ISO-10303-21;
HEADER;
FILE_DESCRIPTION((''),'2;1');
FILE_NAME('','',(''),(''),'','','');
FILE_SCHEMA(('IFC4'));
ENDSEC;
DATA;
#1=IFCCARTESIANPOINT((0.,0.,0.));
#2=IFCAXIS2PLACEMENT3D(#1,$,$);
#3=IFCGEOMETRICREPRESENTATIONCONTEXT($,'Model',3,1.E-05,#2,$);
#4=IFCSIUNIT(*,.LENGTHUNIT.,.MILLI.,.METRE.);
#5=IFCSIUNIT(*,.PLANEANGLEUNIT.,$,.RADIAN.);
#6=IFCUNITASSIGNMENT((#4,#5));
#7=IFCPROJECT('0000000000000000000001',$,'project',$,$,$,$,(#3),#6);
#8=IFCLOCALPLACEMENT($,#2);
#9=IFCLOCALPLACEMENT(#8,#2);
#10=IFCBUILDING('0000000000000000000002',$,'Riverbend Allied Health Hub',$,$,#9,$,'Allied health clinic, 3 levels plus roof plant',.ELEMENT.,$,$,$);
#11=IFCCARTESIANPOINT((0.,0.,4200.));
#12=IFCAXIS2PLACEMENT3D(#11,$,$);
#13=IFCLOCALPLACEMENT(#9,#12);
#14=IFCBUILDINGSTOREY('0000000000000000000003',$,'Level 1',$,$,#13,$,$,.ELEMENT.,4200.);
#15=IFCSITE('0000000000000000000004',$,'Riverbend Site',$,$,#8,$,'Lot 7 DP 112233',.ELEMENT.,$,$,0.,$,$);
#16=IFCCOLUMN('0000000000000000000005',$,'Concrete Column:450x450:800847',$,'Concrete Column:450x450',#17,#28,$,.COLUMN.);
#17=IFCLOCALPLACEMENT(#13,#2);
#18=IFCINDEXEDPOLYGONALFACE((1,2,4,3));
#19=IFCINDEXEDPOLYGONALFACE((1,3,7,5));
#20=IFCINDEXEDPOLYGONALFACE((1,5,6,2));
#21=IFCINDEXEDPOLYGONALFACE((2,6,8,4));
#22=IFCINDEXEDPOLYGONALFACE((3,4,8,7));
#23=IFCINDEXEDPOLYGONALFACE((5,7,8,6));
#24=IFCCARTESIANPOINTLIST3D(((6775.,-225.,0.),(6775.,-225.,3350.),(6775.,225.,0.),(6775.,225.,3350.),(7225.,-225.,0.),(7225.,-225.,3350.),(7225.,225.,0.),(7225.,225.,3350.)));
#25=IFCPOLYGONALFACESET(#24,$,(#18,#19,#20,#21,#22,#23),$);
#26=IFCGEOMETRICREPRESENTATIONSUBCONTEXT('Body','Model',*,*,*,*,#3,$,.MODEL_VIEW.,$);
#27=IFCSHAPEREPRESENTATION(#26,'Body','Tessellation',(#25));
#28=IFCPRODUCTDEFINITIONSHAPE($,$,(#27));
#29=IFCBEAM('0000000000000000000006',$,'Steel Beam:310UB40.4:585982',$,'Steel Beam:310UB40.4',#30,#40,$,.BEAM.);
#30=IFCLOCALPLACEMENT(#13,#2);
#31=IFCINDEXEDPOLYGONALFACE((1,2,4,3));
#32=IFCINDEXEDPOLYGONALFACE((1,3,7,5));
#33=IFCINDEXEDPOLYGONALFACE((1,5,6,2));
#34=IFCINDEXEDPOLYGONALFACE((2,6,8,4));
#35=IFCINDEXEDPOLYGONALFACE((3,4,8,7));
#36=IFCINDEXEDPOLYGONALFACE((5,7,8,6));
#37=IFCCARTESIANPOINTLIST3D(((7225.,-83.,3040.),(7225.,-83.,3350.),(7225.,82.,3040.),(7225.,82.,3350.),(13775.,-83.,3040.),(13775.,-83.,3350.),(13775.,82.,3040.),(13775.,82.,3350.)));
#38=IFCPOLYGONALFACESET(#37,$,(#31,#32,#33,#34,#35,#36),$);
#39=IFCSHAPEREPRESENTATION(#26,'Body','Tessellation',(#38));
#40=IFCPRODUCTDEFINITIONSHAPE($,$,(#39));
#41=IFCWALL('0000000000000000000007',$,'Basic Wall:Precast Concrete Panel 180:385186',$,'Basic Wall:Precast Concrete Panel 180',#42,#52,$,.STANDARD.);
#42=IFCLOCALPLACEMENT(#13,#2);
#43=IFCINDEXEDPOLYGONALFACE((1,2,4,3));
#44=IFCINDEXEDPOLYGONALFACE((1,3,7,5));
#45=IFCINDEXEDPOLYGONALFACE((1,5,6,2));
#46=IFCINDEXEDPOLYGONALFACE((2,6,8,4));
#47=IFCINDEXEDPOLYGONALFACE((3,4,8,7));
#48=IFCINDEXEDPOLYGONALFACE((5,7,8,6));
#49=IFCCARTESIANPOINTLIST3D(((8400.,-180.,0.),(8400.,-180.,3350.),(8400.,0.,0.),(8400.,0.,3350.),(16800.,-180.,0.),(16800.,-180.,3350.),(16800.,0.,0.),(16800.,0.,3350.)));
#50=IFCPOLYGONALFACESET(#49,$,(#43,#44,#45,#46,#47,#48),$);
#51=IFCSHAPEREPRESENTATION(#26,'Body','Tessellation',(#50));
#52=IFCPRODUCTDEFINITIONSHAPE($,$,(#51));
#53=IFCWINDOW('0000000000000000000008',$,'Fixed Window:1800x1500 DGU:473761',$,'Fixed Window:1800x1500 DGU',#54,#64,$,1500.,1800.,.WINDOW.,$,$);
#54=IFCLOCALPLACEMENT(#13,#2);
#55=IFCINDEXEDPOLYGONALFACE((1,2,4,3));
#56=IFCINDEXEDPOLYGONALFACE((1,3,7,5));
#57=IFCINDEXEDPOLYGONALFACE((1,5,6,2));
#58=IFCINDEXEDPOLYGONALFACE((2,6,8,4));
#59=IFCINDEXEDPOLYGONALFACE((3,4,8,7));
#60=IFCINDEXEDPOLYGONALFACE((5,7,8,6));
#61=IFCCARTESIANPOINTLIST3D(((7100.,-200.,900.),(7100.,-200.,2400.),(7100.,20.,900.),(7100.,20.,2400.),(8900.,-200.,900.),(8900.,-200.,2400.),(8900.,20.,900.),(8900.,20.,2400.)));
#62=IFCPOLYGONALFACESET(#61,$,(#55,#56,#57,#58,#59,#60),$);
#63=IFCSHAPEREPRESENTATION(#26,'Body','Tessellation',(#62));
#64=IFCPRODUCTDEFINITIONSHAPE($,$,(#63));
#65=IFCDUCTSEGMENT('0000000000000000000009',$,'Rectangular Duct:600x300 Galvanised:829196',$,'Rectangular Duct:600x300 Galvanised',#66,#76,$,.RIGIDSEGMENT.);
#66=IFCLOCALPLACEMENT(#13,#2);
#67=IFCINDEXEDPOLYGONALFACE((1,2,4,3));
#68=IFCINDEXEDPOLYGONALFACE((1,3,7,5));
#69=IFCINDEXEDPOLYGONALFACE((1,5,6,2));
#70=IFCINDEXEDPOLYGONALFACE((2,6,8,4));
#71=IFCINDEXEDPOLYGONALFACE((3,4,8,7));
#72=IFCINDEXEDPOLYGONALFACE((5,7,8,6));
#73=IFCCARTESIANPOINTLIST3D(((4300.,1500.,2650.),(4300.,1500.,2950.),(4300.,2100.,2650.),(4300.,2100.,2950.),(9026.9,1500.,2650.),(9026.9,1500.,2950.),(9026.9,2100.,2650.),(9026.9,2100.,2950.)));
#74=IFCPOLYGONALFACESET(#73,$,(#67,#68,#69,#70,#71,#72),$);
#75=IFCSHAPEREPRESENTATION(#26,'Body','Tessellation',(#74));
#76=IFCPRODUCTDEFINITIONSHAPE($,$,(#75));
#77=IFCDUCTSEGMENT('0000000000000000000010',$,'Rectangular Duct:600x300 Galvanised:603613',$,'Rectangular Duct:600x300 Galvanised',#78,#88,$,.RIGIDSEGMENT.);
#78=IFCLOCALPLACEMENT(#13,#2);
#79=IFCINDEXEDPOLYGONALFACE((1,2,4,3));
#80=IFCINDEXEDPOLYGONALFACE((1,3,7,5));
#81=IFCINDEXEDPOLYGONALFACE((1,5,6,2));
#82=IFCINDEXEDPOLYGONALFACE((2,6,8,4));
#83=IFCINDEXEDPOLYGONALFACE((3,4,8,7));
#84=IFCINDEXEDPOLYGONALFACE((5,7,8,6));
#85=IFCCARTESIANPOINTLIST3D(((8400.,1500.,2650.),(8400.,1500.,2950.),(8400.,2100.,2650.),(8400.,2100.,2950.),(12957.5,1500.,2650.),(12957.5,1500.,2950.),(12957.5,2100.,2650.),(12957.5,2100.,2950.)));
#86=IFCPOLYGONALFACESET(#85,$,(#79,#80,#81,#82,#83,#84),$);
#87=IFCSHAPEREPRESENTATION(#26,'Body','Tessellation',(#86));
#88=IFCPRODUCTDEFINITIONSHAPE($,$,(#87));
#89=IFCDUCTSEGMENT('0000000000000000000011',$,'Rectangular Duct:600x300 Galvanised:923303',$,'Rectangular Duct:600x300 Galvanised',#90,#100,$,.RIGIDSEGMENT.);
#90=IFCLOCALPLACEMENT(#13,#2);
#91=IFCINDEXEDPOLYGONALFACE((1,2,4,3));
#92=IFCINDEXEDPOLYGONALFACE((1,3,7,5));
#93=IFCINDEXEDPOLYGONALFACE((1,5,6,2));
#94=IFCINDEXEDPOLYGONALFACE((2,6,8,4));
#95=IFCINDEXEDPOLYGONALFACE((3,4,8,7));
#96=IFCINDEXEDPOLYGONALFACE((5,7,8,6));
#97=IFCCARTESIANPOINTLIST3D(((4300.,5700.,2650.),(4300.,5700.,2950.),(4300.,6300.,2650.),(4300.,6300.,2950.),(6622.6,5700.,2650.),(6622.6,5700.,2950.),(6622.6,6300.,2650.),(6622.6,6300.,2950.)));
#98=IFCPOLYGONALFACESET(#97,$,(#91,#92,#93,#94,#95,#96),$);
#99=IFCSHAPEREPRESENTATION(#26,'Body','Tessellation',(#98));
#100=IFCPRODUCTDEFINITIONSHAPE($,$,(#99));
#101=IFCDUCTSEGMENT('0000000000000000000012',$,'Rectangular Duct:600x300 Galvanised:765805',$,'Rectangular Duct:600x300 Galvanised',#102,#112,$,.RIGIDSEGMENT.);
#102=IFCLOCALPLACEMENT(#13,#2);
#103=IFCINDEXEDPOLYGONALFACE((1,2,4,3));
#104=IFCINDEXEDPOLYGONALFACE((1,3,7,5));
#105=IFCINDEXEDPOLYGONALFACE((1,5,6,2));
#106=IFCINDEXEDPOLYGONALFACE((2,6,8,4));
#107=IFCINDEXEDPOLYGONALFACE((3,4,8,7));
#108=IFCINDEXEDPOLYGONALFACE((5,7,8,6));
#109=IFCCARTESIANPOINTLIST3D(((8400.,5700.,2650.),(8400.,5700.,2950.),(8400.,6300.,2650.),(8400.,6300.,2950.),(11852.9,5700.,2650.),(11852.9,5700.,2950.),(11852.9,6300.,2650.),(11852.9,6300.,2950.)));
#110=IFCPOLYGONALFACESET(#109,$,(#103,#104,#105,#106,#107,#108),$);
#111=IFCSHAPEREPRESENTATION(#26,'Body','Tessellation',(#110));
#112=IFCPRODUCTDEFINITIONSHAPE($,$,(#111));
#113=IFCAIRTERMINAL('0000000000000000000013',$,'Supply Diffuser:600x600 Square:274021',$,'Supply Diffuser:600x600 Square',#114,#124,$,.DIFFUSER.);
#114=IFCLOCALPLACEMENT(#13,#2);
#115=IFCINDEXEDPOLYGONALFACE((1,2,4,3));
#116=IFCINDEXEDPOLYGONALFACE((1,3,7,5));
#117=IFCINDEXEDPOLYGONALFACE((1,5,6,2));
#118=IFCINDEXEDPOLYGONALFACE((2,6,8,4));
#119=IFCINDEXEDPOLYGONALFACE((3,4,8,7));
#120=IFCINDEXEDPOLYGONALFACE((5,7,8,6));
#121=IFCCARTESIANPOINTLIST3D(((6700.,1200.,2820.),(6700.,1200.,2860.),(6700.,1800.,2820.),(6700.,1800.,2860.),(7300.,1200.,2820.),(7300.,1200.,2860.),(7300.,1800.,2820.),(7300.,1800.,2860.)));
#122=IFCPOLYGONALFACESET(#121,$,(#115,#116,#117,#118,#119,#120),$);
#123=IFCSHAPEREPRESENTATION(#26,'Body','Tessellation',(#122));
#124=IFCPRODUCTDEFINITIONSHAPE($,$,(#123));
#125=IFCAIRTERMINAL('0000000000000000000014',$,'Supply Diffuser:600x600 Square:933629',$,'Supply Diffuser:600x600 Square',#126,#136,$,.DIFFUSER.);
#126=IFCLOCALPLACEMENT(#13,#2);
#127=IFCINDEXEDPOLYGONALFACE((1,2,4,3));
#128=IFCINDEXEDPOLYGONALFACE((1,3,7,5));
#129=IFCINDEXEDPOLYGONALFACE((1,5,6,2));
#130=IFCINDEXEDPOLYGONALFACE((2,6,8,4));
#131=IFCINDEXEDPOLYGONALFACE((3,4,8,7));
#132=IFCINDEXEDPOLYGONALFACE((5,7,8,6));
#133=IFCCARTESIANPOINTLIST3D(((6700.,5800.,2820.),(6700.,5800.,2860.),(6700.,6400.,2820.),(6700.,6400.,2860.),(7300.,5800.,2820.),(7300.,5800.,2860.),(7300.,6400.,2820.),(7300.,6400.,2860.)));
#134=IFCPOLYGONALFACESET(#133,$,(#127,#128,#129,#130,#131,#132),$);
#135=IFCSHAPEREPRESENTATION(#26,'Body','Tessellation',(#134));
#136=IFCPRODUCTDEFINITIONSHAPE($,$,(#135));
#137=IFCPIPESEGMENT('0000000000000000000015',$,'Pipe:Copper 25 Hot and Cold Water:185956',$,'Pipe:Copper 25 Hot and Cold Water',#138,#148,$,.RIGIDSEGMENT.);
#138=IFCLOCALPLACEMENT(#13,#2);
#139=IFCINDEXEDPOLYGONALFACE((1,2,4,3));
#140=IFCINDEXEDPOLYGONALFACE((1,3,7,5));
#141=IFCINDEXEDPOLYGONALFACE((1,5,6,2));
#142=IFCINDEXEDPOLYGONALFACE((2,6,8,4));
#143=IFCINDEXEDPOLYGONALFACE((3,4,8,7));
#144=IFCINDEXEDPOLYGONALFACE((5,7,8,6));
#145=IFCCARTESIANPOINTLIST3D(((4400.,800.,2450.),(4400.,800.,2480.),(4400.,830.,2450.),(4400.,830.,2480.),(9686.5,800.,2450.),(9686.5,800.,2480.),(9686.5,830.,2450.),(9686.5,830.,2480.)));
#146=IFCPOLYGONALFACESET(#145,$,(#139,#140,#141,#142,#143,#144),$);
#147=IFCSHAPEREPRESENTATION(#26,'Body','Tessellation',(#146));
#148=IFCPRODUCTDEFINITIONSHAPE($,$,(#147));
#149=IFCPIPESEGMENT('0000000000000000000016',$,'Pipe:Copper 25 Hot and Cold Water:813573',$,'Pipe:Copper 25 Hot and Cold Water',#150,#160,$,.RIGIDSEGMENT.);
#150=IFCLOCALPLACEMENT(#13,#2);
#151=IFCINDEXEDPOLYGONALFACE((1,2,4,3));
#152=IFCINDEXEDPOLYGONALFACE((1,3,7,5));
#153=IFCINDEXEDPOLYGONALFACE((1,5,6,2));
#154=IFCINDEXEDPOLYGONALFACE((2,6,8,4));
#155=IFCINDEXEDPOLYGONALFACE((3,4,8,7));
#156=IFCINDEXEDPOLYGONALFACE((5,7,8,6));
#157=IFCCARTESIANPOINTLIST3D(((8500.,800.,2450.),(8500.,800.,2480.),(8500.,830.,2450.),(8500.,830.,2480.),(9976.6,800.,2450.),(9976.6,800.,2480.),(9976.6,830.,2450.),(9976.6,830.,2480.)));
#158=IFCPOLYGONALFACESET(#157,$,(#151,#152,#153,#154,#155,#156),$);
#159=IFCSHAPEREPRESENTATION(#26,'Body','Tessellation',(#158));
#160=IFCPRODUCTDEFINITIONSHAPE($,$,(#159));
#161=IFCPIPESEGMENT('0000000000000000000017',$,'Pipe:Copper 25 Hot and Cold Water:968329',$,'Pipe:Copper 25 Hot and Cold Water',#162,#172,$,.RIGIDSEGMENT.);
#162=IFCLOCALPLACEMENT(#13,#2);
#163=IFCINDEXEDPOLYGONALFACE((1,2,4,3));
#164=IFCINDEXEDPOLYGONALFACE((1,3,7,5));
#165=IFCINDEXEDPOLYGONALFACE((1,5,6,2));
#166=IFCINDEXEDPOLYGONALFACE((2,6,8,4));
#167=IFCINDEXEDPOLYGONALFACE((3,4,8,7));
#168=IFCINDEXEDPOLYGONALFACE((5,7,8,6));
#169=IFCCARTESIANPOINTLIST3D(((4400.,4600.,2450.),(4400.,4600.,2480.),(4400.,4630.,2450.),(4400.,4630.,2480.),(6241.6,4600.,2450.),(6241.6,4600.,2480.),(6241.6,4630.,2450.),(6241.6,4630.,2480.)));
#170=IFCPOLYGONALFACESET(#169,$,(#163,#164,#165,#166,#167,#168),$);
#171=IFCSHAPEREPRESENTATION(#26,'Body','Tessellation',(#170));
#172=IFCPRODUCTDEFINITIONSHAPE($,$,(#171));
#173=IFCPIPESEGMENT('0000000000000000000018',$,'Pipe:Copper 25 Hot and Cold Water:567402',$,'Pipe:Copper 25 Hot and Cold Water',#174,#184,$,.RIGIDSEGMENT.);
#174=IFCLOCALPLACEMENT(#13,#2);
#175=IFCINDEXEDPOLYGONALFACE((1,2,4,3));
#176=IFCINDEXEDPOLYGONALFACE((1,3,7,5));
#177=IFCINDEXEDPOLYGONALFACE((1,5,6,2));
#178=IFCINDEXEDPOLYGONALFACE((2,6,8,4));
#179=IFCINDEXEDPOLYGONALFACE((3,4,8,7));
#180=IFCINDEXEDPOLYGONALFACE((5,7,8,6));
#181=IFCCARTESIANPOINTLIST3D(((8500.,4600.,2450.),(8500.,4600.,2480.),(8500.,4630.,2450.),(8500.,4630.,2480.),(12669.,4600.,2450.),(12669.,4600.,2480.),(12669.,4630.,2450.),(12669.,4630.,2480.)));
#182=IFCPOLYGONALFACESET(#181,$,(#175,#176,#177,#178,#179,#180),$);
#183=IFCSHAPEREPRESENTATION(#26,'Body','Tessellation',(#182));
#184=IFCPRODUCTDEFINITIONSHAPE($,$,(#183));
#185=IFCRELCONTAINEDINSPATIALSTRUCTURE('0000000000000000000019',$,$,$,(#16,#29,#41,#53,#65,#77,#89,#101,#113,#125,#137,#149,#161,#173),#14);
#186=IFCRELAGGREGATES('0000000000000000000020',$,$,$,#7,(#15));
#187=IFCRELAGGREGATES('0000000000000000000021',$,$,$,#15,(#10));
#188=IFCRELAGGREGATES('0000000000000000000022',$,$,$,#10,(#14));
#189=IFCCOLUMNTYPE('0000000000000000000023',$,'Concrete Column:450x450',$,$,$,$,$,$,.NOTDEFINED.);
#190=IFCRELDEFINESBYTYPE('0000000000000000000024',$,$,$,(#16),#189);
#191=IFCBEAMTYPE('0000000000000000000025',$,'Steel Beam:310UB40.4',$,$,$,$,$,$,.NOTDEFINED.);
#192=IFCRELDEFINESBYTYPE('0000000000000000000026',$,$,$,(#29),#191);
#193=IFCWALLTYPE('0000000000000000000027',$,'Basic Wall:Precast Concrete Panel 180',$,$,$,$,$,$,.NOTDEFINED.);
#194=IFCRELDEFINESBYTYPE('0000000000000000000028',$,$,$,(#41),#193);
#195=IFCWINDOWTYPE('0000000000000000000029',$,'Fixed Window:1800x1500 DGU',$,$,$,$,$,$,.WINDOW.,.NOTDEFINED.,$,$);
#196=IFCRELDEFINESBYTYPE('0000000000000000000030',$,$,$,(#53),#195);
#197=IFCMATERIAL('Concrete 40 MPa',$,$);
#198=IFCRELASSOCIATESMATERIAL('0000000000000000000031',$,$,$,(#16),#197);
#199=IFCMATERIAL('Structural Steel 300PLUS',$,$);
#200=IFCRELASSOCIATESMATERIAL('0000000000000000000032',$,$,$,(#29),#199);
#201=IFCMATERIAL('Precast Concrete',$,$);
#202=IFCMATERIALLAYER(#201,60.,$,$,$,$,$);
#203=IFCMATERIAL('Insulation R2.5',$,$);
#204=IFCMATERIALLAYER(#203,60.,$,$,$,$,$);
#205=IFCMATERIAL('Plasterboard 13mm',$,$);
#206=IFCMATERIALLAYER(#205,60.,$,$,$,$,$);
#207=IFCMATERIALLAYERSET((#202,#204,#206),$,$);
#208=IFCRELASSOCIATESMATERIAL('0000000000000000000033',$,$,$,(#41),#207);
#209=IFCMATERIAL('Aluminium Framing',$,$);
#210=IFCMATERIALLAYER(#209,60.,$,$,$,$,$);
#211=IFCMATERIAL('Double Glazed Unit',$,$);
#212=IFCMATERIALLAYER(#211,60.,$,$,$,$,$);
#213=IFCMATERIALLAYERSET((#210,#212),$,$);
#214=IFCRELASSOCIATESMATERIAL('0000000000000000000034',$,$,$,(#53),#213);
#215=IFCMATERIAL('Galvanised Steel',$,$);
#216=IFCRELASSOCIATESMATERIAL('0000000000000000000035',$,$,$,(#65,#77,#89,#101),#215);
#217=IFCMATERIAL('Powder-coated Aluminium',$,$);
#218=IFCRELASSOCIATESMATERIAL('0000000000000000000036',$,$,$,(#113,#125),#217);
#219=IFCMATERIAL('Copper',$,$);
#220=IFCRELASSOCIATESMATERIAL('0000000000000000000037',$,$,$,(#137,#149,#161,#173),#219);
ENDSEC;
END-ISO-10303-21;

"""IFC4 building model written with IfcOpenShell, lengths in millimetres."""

from ifc_helpers import new_model, si_unit, frame, frame_2d, origin, place, context, subcontext, project, spatial, rectangle, extrude, material, layer, layer_set, layer_usage, type_object, element, save


model = new_model("IFC4")

# Units and contexts
model_context = context("Model", 3, precision=1e-05, world=origin())
body_context = subcontext(model_context, "Body", "Model", "MODEL_VIEW")
ifc_project = project(units=[si_unit("LENGTHUNIT", "METRE", prefix="MILLI"), si_unit("PLANEANGLEUNIT", "RADIAN")], contexts=[model_context])

# Site, building, storey
site_placement = place(None, origin())
site = spatial("IfcSite", under=ifc_project, at=site_placement, Name="Riverbend Site", LongName="Lot 7 DP 112233", CompositionType="ELEMENT", RefElevation=0.0)
building_placement = place(site_placement, origin())
building = spatial("IfcBuilding", under=site, at=building_placement, Name="Riverbend Allied Health Hub", LongName="Allied health clinic, 3 levels plus roof plant", CompositionType="ELEMENT")
storey_placement = place(building_placement, frame((0.0, 0.0, 4200.0)))
storey = spatial("IfcBuildingStorey", under=building, at=storey_placement, Name="Level 1", CompositionType="ELEMENT", Elevation=4200.0)

# Column
ifc_material_1 = material(Name="Concrete 40 MPa")
column_type = type_object("IfcColumnType", Name="Concrete Column:450x450", PredefinedType="NOTDEFINED")
column_placement = place(storey_placement, frame((6775.0, -225.0, 0.0)))
element("IfcColumn", 1, at=column_placement, inside=storey, type_object=column_type, material=ifc_material_1, Name="Concrete Column:450x450:800847", ObjectType="Concrete Column:450x450", PredefinedType="COLUMN", context=body_context, shape_type="SweptSolid", body=[
    extrude(rectangle(XDim=450.0, YDim=450.0, at=frame_2d((225.0, 225.0))), origin(), (0.0, 0.0, 1.0), 3350.0),
])

# Beam
ifc_material_2 = material(Name="Structural Steel 300PLUS")
beam_type = type_object("IfcBeamType", Name="Steel Beam:310UB40.4", PredefinedType="NOTDEFINED")
beam_placement = place(storey_placement, frame((7225.0, -83.0, 3040.0)))
element("IfcBeam", 2, at=beam_placement, inside=storey, type_object=beam_type, material=ifc_material_2, Name="Steel Beam:310UB40.4:585982", ObjectType="Steel Beam:310UB40.4", PredefinedType="BEAM", context=body_context, shape_type="SweptSolid", body=[
    extrude(rectangle(XDim=6550.0, YDim=165.0, at=frame_2d((3275.0, 82.5))), origin(), (0.0, 0.0, 1.0), 310.0),
])

# Wall
ifc_material_3 = material(Name="Precast Concrete")
ifc_layer_1 = layer(ifc_material_3, 60.0)
ifc_material_4 = material(Name="Insulation R2.5")
ifc_layer_2 = layer(ifc_material_4, 60.0)
ifc_material_5 = material(Name="Plasterboard 13mm")
ifc_layer_3 = layer(ifc_material_5, 60.0)
ifc_layer_set_1 = layer_set([ifc_layer_1, ifc_layer_2, ifc_layer_3])
ifc_layer_usage_1 = layer_usage(ifc_layer_set_1, "AXIS2", "POSITIVE", 0.0)
wall_type = type_object("IfcWallType", Name="Basic Wall:Precast Concrete Panel 180", PredefinedType="NOTDEFINED")
wall_placement = place(storey_placement, frame((8400.0, -180.0, 0.0)))
element("IfcWall", 3, at=wall_placement, inside=storey, type_object=wall_type, material=ifc_layer_usage_1, Name="Basic Wall:Precast Concrete Panel 180:385186", ObjectType="Basic Wall:Precast Concrete Panel 180", PredefinedType="STANDARD", context=body_context, shape_type="SweptSolid", body=[
    extrude(rectangle(XDim=8400.0, YDim=180.0, at=frame_2d((4200.0, 90.0))), origin(), (0.0, 0.0, 1.0), 3350.0),
])

# Window
ifc_material_6 = material(Name="Aluminium Framing")
ifc_layer_4 = layer(ifc_material_6, 60.0)
ifc_material_7 = material(Name="Double Glazed Unit")
ifc_layer_5 = layer(ifc_material_7, 60.0)
ifc_layer_set_2 = layer_set([ifc_layer_4, ifc_layer_5])
ifc_layer_usage_2 = layer_usage(ifc_layer_set_2, "AXIS2", "POSITIVE", 0.0)
window_type = type_object("IfcWindowType", Name="Fixed Window:1800x1500 DGU", PartitioningType="NOTDEFINED", PredefinedType="WINDOW")
window_placement = place(storey_placement, frame((7100.0, -200.0, 900.0)))
element("IfcWindow", 4, at=window_placement, inside=storey, type_object=window_type, material=ifc_layer_usage_2, Name="Fixed Window:1800x1500 DGU:473761", ObjectType="Fixed Window:1800x1500 DGU", OverallHeight=1500.0, OverallWidth=1800.0, PredefinedType="WINDOW", context=body_context, shape_type="SweptSolid", body=[
    extrude(rectangle(XDim=1800.0, YDim=220.0, at=frame_2d((900.0, 110.0))), origin(), (0.0, 0.0, 1.0), 1500.0),
])

# Duct segments
ifc_material_8 = material(Name="Galvanised Steel")
duct_segment_1_placement = place(storey_placement, frame((4300.0, 1500.0, 2650.0)))
element("IfcDuctSegment", 5, at=duct_segment_1_placement, inside=storey, material=ifc_material_8, Name="Rectangular Duct:600x300 Galvanised:829196", ObjectType="Rectangular Duct:600x300 Galvanised", PredefinedType="RIGIDSEGMENT", context=body_context, shape_type="SweptSolid", body=[
    extrude(rectangle(XDim=4726.9, YDim=600.0, at=frame_2d((2363.5, 300.0))), origin(), (0.0, 0.0, 1.0), 300.0),
])
duct_segment_2_placement = place(storey_placement, frame((8400.0, 1500.0, 2650.0)))
element("IfcDuctSegment", 6, at=duct_segment_2_placement, inside=storey, material=ifc_material_8, Name="Rectangular Duct:600x300 Galvanised:603613", ObjectType="Rectangular Duct:600x300 Galvanised", PredefinedType="RIGIDSEGMENT", context=body_context, shape_type="SweptSolid", body=[
    extrude(rectangle(XDim=4557.5, YDim=600.0, at=frame_2d((2278.7, 300.0))), origin(), (0.0, 0.0, 1.0), 300.0),
])
duct_segment_3_placement = place(storey_placement, frame((4300.0, 5700.0, 2650.0)))
element("IfcDuctSegment", 7, at=duct_segment_3_placement, inside=storey, material=ifc_material_8, Name="Rectangular Duct:600x300 Galvanised:923303", ObjectType="Rectangular Duct:600x300 Galvanised", PredefinedType="RIGIDSEGMENT", context=body_context, shape_type="SweptSolid", body=[
    extrude(rectangle(XDim=2322.6, YDim=600.0, at=frame_2d((1161.3, 300.0))), origin(), (0.0, 0.0, 1.0), 300.0),
])
duct_segment_4_placement = place(storey_placement, frame((8400.0, 5700.0, 2650.0)))
element("IfcDuctSegment", 8, at=duct_segment_4_placement, inside=storey, material=ifc_material_8, Name="Rectangular Duct:600x300 Galvanised:765805", ObjectType="Rectangular Duct:600x300 Galvanised", PredefinedType="RIGIDSEGMENT", context=body_context, shape_type="SweptSolid", body=[
    extrude(rectangle(XDim=3452.9, YDim=600.0, at=frame_2d((1726.4, 300.0))), origin(), (0.0, 0.0, 1.0), 300.0),
])

# Air terminals
ifc_material_9 = material(Name="Powder-coated Aluminium")
for number, where, name in (
    (9, (6700.0, 1200.0, 2820.0), "Supply Diffuser:600x600 Square:274021"),
    (10, (6700.0, 5800.0, 2820.0), "Supply Diffuser:600x600 Square:933629"),
):
    element("IfcAirTerminal", number, at=place(storey_placement, frame(where)), inside=storey, material=ifc_material_9, Name=name, ObjectType="Supply Diffuser:600x600 Square", PredefinedType="DIFFUSER", context=body_context, shape_type="SweptSolid", body=[
        extrude(rectangle(XDim=600.0, YDim=600.0, at=frame_2d((300.0, 300.0))), origin(), (0.0, 0.0, 1.0), 40.0),
    ])

# Pipe segments
ifc_material_10 = material(Name="Copper")
pipe_segment_1_placement = place(storey_placement, frame((4400.0, 800.0, 2450.0)))
element("IfcPipeSegment", 11, at=pipe_segment_1_placement, inside=storey, material=ifc_material_10, Name="Pipe:Copper 25 Hot and Cold Water:185956", ObjectType="Pipe:Copper 25 Hot and Cold Water", PredefinedType="RIGIDSEGMENT", context=body_context, shape_type="SweptSolid", body=[
    extrude(rectangle(XDim=5286.5, YDim=30.0, at=frame_2d((2643.2, 15.0))), origin(), (0.0, 0.0, 1.0), 30.0),
])
pipe_segment_2_placement = place(storey_placement, frame((8500.0, 800.0, 2450.0)))
element("IfcPipeSegment", 12, at=pipe_segment_2_placement, inside=storey, material=ifc_material_10, Name="Pipe:Copper 25 Hot and Cold Water:813573", ObjectType="Pipe:Copper 25 Hot and Cold Water", PredefinedType="RIGIDSEGMENT", context=body_context, shape_type="SweptSolid", body=[
    extrude(rectangle(XDim=1476.6, YDim=30.0, at=frame_2d((738.3, 15.0))), origin(), (0.0, 0.0, 1.0), 30.0),
])
pipe_segment_3_placement = place(storey_placement, frame((4400.0, 4600.0, 2450.0)))
element("IfcPipeSegment", 13, at=pipe_segment_3_placement, inside=storey, material=ifc_material_10, Name="Pipe:Copper 25 Hot and Cold Water:968329", ObjectType="Pipe:Copper 25 Hot and Cold Water", PredefinedType="RIGIDSEGMENT", context=body_context, shape_type="SweptSolid", body=[
    extrude(rectangle(XDim=1841.6, YDim=30.0, at=frame_2d((920.8, 15.0))), origin(), (0.0, 0.0, 1.0), 30.0),
])
pipe_segment_4_placement = place(storey_placement, frame((8500.0, 4600.0, 2450.0)))
element("IfcPipeSegment", 14, at=pipe_segment_4_placement, inside=storey, material=ifc_material_10, Name="Pipe:Copper 25 Hot and Cold Water:567402", ObjectType="Pipe:Copper 25 Hot and Cold Water", PredefinedType="RIGIDSEGMENT", context=body_context, shape_type="SweptSolid", body=[
    extrude(rectangle(XDim=4169.0, YDim=30.0, at=frame_2d((2084.5, 15.0))), origin(), (0.0, 0.0, 1.0), 30.0),
])

save(model, "model.ifc")
